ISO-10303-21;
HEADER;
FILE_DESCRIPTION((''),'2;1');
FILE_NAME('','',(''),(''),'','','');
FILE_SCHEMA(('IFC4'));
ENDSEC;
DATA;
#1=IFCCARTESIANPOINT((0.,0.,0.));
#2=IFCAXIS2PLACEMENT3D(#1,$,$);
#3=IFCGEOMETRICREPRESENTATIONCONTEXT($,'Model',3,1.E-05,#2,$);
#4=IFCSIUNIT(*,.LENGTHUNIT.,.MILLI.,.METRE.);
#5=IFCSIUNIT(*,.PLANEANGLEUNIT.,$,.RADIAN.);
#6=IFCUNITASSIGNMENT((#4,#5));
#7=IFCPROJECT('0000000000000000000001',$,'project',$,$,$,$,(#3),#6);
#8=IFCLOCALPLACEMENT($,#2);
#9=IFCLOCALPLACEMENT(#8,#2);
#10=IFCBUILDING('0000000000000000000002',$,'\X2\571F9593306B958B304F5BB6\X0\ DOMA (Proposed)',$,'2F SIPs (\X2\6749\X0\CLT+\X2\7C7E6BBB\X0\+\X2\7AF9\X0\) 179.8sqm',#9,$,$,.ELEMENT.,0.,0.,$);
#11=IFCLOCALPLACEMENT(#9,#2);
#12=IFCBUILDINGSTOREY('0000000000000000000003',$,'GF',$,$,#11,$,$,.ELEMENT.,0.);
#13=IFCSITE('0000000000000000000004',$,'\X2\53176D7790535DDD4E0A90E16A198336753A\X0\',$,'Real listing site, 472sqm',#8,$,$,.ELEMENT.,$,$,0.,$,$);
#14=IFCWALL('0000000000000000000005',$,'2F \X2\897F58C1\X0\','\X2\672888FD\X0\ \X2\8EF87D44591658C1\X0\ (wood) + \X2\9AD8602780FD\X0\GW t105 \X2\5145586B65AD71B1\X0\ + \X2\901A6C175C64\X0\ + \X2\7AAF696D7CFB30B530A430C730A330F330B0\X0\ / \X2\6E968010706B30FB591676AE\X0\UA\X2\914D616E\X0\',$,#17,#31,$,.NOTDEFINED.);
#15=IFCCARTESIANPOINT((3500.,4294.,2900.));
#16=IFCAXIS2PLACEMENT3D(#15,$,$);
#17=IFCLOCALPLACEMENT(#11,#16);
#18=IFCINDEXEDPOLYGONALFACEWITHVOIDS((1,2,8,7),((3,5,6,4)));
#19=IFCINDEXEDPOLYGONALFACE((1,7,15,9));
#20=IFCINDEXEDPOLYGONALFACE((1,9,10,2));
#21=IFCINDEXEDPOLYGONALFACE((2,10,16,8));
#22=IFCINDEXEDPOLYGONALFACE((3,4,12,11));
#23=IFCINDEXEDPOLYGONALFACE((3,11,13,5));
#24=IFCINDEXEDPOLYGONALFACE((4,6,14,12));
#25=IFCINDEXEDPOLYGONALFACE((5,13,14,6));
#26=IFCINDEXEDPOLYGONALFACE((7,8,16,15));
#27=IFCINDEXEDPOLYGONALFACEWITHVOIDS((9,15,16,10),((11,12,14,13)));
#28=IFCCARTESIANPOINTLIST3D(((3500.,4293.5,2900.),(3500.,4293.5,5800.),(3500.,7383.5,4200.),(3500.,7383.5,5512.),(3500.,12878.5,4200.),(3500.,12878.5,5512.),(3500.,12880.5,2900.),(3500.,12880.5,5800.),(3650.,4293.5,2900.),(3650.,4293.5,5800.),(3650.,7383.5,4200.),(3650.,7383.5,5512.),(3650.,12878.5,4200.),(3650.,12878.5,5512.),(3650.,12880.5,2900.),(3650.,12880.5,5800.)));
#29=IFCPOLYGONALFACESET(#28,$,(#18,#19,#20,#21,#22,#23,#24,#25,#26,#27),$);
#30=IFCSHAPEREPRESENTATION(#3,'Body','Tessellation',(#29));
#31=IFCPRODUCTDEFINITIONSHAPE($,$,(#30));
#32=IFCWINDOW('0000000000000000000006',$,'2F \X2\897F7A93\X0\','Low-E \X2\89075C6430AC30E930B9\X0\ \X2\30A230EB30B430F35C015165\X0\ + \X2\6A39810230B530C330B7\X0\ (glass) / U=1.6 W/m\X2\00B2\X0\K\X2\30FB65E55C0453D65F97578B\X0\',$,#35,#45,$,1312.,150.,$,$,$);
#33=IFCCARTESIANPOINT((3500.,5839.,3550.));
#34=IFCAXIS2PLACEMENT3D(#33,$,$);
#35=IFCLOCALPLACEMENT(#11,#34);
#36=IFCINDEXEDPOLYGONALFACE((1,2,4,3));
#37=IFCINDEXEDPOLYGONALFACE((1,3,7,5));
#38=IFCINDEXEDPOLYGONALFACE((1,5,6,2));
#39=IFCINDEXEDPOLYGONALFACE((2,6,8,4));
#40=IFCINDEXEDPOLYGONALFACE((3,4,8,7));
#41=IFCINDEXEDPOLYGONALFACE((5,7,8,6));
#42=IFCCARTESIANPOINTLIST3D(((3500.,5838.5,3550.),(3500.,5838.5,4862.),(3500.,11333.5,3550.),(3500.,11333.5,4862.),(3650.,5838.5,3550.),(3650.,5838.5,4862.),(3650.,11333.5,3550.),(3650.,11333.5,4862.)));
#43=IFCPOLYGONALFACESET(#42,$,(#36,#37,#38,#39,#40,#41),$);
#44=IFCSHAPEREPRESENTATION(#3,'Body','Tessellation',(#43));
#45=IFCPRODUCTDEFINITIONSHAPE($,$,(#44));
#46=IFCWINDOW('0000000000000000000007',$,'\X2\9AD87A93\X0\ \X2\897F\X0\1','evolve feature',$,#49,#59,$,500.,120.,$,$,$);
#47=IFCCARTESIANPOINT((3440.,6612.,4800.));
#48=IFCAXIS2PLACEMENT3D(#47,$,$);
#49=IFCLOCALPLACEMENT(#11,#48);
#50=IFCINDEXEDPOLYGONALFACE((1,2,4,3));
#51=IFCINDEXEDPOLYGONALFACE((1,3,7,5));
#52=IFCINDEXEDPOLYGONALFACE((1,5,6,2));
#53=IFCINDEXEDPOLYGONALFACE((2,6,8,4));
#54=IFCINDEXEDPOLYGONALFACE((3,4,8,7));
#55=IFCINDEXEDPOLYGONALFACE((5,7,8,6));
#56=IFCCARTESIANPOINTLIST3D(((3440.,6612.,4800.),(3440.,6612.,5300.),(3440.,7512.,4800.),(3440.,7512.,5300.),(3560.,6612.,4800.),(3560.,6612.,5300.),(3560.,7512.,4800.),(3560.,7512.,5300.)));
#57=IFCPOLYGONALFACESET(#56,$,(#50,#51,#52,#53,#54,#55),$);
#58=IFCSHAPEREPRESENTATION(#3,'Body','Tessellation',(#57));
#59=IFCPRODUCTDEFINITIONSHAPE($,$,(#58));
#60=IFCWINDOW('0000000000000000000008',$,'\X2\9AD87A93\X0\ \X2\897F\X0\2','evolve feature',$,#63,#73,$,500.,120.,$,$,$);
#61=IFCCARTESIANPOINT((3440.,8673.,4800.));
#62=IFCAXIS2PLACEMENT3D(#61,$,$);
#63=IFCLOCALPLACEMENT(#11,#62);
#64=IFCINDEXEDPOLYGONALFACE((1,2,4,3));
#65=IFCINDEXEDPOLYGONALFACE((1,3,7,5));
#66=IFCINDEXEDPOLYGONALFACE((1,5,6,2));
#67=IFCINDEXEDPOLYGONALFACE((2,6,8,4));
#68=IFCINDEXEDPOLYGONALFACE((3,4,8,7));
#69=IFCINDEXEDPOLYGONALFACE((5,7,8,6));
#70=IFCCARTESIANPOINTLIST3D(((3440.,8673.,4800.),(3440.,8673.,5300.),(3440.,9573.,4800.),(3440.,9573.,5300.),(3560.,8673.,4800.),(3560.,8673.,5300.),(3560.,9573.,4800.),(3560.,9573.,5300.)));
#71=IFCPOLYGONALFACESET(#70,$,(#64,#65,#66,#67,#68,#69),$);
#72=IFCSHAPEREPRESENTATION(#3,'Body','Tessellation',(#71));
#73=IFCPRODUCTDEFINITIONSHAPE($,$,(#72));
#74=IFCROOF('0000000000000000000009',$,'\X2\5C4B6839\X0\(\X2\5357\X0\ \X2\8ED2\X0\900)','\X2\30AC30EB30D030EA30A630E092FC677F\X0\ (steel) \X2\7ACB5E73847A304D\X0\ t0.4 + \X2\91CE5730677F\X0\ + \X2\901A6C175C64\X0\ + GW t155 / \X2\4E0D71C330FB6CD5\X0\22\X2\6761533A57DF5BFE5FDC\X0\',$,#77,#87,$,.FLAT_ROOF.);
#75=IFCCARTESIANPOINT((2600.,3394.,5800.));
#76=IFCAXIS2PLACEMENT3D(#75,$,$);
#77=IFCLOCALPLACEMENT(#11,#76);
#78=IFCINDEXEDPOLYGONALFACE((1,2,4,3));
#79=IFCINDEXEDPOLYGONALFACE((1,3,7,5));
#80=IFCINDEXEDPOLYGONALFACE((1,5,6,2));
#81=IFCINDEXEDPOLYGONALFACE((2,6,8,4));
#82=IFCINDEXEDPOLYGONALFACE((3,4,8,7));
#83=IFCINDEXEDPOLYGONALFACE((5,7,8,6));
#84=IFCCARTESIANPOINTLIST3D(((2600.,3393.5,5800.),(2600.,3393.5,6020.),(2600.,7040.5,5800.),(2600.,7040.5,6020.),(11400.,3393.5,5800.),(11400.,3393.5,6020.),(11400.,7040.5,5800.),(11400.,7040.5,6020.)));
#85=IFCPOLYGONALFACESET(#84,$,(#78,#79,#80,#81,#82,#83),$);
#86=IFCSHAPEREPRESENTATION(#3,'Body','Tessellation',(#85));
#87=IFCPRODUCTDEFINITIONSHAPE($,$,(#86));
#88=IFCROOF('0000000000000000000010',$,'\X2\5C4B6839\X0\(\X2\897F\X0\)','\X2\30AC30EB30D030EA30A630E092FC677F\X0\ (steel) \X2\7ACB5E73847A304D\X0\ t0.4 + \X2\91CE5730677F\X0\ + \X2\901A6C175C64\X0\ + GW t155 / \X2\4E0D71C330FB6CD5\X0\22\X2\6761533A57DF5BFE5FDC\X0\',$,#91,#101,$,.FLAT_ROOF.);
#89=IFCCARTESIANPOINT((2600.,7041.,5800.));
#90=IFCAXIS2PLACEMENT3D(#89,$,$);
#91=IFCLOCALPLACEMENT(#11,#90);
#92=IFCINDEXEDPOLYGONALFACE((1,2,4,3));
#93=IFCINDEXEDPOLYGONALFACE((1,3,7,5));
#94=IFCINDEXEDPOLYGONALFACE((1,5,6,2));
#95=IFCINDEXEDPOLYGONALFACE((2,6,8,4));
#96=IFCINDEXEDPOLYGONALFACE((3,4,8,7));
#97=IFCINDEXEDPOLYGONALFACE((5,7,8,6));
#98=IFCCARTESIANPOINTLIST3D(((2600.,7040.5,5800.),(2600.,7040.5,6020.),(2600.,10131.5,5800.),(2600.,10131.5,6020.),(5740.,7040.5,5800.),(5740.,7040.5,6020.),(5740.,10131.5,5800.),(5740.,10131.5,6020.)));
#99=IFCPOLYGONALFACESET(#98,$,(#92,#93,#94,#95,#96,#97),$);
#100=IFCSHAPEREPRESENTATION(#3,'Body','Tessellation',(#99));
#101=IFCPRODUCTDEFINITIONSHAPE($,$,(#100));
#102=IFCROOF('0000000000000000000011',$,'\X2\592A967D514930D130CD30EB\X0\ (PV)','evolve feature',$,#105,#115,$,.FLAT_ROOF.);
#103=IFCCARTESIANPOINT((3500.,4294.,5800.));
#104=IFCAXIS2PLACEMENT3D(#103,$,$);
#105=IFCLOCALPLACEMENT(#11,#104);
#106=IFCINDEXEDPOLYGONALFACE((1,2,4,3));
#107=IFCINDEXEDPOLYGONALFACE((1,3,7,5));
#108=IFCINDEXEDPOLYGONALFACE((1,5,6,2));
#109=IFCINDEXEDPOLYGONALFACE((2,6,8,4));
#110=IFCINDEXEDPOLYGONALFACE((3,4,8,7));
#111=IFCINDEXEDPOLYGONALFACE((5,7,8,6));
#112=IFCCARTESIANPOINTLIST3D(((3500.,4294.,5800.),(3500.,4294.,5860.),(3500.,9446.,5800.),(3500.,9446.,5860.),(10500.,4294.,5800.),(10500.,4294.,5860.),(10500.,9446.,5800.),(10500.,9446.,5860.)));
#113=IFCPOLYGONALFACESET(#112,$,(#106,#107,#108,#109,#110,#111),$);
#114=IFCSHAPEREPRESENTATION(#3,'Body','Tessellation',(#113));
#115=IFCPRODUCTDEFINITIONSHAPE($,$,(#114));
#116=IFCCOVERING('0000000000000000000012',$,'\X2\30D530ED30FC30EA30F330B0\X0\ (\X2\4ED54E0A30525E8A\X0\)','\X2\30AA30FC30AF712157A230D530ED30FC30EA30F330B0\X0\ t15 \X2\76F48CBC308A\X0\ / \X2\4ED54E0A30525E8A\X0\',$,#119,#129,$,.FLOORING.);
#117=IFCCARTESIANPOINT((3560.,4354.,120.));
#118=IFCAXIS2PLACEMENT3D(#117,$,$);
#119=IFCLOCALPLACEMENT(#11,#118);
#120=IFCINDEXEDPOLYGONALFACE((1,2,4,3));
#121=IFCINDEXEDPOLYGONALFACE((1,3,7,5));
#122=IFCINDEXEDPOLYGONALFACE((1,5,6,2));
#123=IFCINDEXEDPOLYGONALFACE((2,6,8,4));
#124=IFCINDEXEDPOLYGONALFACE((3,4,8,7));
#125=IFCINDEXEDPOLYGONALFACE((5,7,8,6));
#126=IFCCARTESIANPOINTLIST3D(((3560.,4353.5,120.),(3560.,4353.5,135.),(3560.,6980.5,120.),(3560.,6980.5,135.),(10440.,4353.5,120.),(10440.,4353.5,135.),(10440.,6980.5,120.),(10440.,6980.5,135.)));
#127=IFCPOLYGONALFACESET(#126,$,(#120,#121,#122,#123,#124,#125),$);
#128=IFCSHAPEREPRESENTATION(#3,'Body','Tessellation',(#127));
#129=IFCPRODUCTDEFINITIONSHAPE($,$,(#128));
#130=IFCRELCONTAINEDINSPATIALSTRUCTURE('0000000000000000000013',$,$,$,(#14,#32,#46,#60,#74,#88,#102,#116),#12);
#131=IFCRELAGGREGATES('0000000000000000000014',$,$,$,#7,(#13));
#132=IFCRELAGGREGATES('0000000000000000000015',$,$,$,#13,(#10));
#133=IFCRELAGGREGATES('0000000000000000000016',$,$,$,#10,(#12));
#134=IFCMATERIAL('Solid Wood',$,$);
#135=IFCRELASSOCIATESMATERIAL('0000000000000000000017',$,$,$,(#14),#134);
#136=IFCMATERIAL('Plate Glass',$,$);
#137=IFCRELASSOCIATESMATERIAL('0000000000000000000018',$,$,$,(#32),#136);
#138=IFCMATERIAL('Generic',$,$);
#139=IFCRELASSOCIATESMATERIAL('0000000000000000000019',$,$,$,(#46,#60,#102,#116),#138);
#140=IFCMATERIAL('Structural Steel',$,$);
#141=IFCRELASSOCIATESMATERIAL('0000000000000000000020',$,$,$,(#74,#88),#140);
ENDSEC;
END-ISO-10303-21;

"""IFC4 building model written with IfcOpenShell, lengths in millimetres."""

from ifc_helpers import new_model, si_unit, frame, frame_2d, origin, place, context, project, spatial, rectangle, extrude, material, element, fill, save


model = new_model("IFC4")

# Units and contexts
model_context = context("Model", 3, precision=1e-05, world=origin())
ifc_project = project(units=[si_unit("LENGTHUNIT", "METRE", prefix="MILLI"), si_unit("PLANEANGLEUNIT", "RADIAN")], contexts=[model_context])

# Site, building, storey
site_placement = place(None, origin())
site = spatial("IfcSite", under=ifc_project, at=site_placement, Name="北海道川上郡標茶町", ObjectType="Real listing site, 472sqm", CompositionType="ELEMENT", RefElevation=0.0)
building_placement = place(site_placement, origin())
building = spatial("IfcBuilding", under=site, at=building_placement, Name="土間に開く家 DOMA (Proposed)", ObjectType="2F SIPs (杉CLT+籾殻+竹) 179.8sqm", CompositionType="ELEMENT", ElevationOfRefHeight=0.0, ElevationOfTerrain=0.0)
storey_placement = place(building_placement, origin())
storey = spatial("IfcBuildingStorey", under=building, at=storey_placement, Name="GF", CompositionType="ELEMENT", Elevation=0.0)

# Shared definitions
ifc_material_1 = material(Name="Solid Wood")
ifc_material_2 = material(Name="Generic")

# Shared definitions
ifc_material_3 = material(Name="Plate Glass")

# Wall, openings, windows
wall_1_placement = place(storey_placement, frame((3500.0, 4294.0, 2900.0)))
wall_1 = element("IfcWall", 1, at=wall_1_placement, inside=storey, material=ifc_material_1, Name="2F 西壁", Description="木製 軸組外壁 (wood) + 高性能GW t105 充填断熱 + 通気層 + 窯業系サイディング / 準耐火・外皮UA配慮", PredefinedType="NOTDEFINED", context=model_context, shape_type="SweptSolid", body=[
    extrude(rectangle(XDim=150.0, YDim=8587.0, at=frame_2d((75.0, 4293.0))), frame((3500.0, 4294.0, 2900.0)), (0.0, 0.0, 1.0), 2900.0),
])
opening_1_placement = place(storey_placement, frame((3500.0, 5839.0, 3550.0)))
opening_1 = element("IfcOpeningElement", 2, at=opening_1_placement, cuts=wall_1, PredefinedType="NOTDEFINED", context=model_context, shape_type="SweptSolid", body=[
    extrude(rectangle(XDim=150.0, YDim=5495.0, at=frame_2d((75.0, 2747.0))), frame((3500.0, 5839.0, 3550.0)), (0.0, 0.0, 1.0), 1312.0),
])
opening_2_placement = place(storey_placement, frame((3440.0, 6612.0, 4800.0)))
opening_2 = element("IfcOpeningElement", 3, at=opening_2_placement, cuts=wall_1, PredefinedType="NOTDEFINED", context=model_context, shape_type="SweptSolid", body=[
    extrude(rectangle(XDim=120.0, YDim=900.0, at=frame_2d((60.0, 450.0))), frame((3440.0, 6612.0, 4800.0)), (0.0, 0.0, 1.0), 500.0),
])
opening_3_placement = place(storey_placement, frame((3440.0, 8673.0, 4800.0)))
opening_3 = element("IfcOpeningElement", 4, at=opening_3_placement, cuts=wall_1, PredefinedType="NOTDEFINED", context=model_context, shape_type="SweptSolid", body=[
    extrude(rectangle(XDim=120.0, YDim=900.0, at=frame_2d((60.0, 450.0))), frame((3440.0, 8673.0, 4800.0)), (0.0, 0.0, 1.0), 500.0),
])
window_1_placement = place(storey_placement, frame((3500.0, 5839.0, 3550.0)))
window_1 = element("IfcWindow", 5, at=window_1_placement, inside=storey, material=ifc_material_3, Name="2F 西窓", Description="Low-E 複層ガラス アルゴン封入 + 樹脂サッシ (glass) / U=1.6 W/m²K・日射取得型", OverallHeight=1312.0, OverallWidth=150.0, context=model_context, shape_type="SweptSolid", body=[
    extrude(rectangle(XDim=150.0, YDim=5495.0, at=frame_2d((75.0, 2747.0))), frame((3500.0, 5839.0, 3550.0)), (0.0, 0.0, 1.0), 1312.0),
])
fill(opening_1, window_1)
window_2_placement = place(storey_placement, frame((3440.0, 6612.0, 4800.0)))
window_2 = element("IfcWindow", 6, at=window_2_placement, inside=storey, material=ifc_material_2, Name="高窓 西1", Description="evolve feature", OverallHeight=500.0, OverallWidth=120.0, context=model_context, shape_type="SweptSolid", body=[
    extrude(rectangle(XDim=120.0, YDim=900.0, at=frame_2d((60.0, 450.0))), frame((3440.0, 6612.0, 4800.0)), (0.0, 0.0, 1.0), 500.0),
])
fill(opening_2, window_2)
window_3_placement = place(storey_placement, frame((3440.0, 8673.0, 4800.0)))
window_3 = element("IfcWindow", 7, at=window_3_placement, inside=storey, material=ifc_material_2, Name="高窓 西2", Description="evolve feature", OverallHeight=500.0, OverallWidth=120.0, context=model_context, shape_type="SweptSolid", body=[
    extrude(rectangle(XDim=120.0, YDim=900.0, at=frame_2d((60.0, 450.0))), frame((3440.0, 8673.0, 4800.0)), (0.0, 0.0, 1.0), 500.0),
])
fill(opening_3, window_3)

# Roofs
ifc_material_4 = material(Name="Structural Steel")
roof_1_placement = place(storey_placement, frame((2600.0, 3394.0, 5800.0)))
element("IfcRoof", 8, at=roof_1_placement, inside=storey, material=ifc_material_4, Name="屋根(南 軒900)", Description="ガルバリウム鋼板 (steel) 立平葺き t0.4 + 野地板 + 通気層 + GW t155 / 不燃・法22条区域対応", PredefinedType="FLAT_ROOF", context=model_context, shape_type="SweptSolid", body=[
    extrude(rectangle(XDim=8800.0, YDim=3647.0, at=frame_2d((4400.0, 1823.0))), frame((2600.0, 3394.0, 5800.0)), (0.0, 0.0, 1.0), 220.0),
])
roof_2_placement = place(storey_placement, frame((2600.0, 7041.0, 5800.0)))
element("IfcRoof", 9, at=roof_2_placement, inside=storey, material=ifc_material_4, Name="屋根(西)", Description="ガルバリウム鋼板 (steel) 立平葺き t0.4 + 野地板 + 通気層 + GW t155 / 不燃・法22条区域対応", PredefinedType="FLAT_ROOF", context=model_context, shape_type="SweptSolid", body=[
    extrude(rectangle(XDim=3140.0, YDim=3091.0, at=frame_2d((1570.0, 1545.0))), frame((2600.0, 7041.0, 5800.0)), (0.0, 0.0, 1.0), 220.0),
])
roof_3_placement = place(storey_placement, frame((3500.0, 4294.0, 5800.0)))
element("IfcRoof", 10, at=roof_3_placement, inside=storey, material=ifc_material_2, Name="太陽光パネル (PV)", Description="evolve feature", PredefinedType="FLAT_ROOF", context=model_context, shape_type="SweptSolid", body=[
    extrude(rectangle(XDim=7000.0, YDim=5152.0, at=frame_2d((3500.0, 2576.0))), frame((3500.0, 4294.0, 5800.0)), (0.0, 0.0, 1.0), 60.0),
])

# Covering
covering_placement = place(storey_placement, frame((3560.0, 4354.0, 120.0)))
element("IfcCovering", 11, at=covering_placement, inside=storey, material=ifc_material_2, Name="フローリング (仕上げ床)", Description="オーク無垢フローリング t15 直貼り / 仕上げ床", PredefinedType="FLOORING", context=model_context, shape_type="SweptSolid", body=[
    extrude(rectangle(XDim=6880.0, YDim=2627.0, at=frame_2d((3440.0, 1313.0))), frame((3560.0, 4354.0, 120.0)), (0.0, 0.0, 1.0), 15.0),
])

save(model, "model.ifc")
